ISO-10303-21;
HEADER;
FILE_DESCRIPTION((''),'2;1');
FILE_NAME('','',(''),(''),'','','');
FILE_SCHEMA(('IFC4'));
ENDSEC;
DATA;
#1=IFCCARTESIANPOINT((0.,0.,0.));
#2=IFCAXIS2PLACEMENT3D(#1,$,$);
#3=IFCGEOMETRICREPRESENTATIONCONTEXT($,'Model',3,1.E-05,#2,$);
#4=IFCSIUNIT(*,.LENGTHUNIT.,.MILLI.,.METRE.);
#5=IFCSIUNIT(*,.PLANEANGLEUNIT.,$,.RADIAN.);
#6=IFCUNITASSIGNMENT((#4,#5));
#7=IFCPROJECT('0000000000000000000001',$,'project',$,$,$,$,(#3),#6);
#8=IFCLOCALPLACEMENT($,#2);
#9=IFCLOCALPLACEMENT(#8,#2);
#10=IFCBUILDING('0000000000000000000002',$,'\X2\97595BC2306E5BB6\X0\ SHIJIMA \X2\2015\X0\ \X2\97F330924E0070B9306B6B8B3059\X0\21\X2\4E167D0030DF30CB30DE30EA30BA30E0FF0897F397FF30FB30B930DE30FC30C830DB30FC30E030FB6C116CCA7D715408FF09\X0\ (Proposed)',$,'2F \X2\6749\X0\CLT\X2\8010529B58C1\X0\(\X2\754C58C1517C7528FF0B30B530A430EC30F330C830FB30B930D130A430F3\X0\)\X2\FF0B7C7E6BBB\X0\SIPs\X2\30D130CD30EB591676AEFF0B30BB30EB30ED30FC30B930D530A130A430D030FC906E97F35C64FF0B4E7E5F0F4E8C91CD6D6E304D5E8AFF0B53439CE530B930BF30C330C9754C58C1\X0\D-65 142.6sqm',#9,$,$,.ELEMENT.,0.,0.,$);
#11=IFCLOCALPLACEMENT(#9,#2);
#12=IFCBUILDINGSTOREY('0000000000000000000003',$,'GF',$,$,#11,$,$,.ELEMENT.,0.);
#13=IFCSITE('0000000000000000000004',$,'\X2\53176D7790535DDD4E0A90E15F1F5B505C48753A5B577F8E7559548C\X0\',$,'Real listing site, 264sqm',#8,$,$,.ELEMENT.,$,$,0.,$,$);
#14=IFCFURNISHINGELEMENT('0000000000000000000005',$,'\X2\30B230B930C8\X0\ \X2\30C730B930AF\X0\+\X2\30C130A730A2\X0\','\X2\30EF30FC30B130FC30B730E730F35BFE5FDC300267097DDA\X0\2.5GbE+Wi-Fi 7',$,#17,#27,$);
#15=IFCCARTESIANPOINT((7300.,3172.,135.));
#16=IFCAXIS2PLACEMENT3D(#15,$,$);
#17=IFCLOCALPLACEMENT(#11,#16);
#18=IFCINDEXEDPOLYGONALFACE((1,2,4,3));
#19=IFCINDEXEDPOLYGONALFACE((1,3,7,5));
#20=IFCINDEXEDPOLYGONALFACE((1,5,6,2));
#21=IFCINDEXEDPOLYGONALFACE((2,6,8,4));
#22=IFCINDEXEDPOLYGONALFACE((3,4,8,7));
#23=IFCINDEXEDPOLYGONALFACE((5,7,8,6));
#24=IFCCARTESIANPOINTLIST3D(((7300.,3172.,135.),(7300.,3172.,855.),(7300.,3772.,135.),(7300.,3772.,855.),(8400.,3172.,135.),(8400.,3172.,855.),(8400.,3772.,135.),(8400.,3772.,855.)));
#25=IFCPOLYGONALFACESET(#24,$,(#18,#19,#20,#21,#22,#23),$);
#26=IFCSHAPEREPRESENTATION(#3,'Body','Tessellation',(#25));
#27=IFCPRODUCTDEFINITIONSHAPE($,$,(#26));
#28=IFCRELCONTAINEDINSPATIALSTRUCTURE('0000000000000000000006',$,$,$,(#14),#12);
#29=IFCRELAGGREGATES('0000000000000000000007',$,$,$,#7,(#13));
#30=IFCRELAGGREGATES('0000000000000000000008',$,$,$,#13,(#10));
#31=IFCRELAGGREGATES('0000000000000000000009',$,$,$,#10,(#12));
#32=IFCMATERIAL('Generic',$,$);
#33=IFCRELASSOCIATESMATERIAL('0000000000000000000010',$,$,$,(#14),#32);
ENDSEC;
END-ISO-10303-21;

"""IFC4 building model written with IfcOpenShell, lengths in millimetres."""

from ifc_helpers import new_model, si_unit, frame, frame_2d, origin, place, context, project, spatial, rectangle, extrude, material, element, save


model = new_model("IFC4")

# Units and contexts
model_context = context("Model", 3, precision=1e-05, world=origin())
ifc_project = project(units=[si_unit("LENGTHUNIT", "METRE", prefix="MILLI"), si_unit("PLANEANGLEUNIT", "RADIAN")], contexts=[model_context])

# Site, building, storey
site_placement = place(None, origin())
site = spatial("IfcSite", under=ifc_project, at=site_placement, Name="北海道川上郡弟子屈町字美留和", ObjectType="Real listing site, 264sqm", CompositionType="ELEMENT", RefElevation=0.0)
building_placement = place(site_placement, origin())
building = spatial("IfcBuilding", under=site, at=building_placement, Name="静寂の家 SHIJIMA ― 音を一点に残す21世紀ミニマリズム（音響・スマートホーム・民泊統合） (Proposed)", ObjectType="2F 杉CLT耐力壁(界壁兼用＋サイレント・スパイン)＋籾殻SIPsパネル外皮＋セルロースファイバー遮音層＋乾式二重浮き床＋千鳥スタッド界壁D-65 142.6sqm", CompositionType="ELEMENT", ElevationOfRefHeight=0.0, ElevationOfTerrain=0.0)
storey_placement = place(building_placement, origin())
storey = spatial("IfcBuildingStorey", under=building, at=storey_placement, Name="GF", CompositionType="ELEMENT", Elevation=0.0)

# Shared definitions
ifc_material_1 = material(Name="Generic")

# Furnishing element
furnishing_1_placement = place(storey_placement, frame((7300.0, 3172.0, 135.0)))
element("IfcFurnishingElement", 1, at=furnishing_1_placement, inside=storey, material=ifc_material_1, Name="ゲスト デスク+チェア", Description="ワーケーション対応。有線2.5GbE+Wi-Fi 7", context=model_context, shape_type="SweptSolid", body=[
    extrude(rectangle(XDim=1100.0, YDim=600.0, at=frame_2d((550.0, 300.0))), frame((7300.0, 3172.0, 135.0)), (0.0, 0.0, 1.0), 720.0),
])

save(model, "model.ifc")
